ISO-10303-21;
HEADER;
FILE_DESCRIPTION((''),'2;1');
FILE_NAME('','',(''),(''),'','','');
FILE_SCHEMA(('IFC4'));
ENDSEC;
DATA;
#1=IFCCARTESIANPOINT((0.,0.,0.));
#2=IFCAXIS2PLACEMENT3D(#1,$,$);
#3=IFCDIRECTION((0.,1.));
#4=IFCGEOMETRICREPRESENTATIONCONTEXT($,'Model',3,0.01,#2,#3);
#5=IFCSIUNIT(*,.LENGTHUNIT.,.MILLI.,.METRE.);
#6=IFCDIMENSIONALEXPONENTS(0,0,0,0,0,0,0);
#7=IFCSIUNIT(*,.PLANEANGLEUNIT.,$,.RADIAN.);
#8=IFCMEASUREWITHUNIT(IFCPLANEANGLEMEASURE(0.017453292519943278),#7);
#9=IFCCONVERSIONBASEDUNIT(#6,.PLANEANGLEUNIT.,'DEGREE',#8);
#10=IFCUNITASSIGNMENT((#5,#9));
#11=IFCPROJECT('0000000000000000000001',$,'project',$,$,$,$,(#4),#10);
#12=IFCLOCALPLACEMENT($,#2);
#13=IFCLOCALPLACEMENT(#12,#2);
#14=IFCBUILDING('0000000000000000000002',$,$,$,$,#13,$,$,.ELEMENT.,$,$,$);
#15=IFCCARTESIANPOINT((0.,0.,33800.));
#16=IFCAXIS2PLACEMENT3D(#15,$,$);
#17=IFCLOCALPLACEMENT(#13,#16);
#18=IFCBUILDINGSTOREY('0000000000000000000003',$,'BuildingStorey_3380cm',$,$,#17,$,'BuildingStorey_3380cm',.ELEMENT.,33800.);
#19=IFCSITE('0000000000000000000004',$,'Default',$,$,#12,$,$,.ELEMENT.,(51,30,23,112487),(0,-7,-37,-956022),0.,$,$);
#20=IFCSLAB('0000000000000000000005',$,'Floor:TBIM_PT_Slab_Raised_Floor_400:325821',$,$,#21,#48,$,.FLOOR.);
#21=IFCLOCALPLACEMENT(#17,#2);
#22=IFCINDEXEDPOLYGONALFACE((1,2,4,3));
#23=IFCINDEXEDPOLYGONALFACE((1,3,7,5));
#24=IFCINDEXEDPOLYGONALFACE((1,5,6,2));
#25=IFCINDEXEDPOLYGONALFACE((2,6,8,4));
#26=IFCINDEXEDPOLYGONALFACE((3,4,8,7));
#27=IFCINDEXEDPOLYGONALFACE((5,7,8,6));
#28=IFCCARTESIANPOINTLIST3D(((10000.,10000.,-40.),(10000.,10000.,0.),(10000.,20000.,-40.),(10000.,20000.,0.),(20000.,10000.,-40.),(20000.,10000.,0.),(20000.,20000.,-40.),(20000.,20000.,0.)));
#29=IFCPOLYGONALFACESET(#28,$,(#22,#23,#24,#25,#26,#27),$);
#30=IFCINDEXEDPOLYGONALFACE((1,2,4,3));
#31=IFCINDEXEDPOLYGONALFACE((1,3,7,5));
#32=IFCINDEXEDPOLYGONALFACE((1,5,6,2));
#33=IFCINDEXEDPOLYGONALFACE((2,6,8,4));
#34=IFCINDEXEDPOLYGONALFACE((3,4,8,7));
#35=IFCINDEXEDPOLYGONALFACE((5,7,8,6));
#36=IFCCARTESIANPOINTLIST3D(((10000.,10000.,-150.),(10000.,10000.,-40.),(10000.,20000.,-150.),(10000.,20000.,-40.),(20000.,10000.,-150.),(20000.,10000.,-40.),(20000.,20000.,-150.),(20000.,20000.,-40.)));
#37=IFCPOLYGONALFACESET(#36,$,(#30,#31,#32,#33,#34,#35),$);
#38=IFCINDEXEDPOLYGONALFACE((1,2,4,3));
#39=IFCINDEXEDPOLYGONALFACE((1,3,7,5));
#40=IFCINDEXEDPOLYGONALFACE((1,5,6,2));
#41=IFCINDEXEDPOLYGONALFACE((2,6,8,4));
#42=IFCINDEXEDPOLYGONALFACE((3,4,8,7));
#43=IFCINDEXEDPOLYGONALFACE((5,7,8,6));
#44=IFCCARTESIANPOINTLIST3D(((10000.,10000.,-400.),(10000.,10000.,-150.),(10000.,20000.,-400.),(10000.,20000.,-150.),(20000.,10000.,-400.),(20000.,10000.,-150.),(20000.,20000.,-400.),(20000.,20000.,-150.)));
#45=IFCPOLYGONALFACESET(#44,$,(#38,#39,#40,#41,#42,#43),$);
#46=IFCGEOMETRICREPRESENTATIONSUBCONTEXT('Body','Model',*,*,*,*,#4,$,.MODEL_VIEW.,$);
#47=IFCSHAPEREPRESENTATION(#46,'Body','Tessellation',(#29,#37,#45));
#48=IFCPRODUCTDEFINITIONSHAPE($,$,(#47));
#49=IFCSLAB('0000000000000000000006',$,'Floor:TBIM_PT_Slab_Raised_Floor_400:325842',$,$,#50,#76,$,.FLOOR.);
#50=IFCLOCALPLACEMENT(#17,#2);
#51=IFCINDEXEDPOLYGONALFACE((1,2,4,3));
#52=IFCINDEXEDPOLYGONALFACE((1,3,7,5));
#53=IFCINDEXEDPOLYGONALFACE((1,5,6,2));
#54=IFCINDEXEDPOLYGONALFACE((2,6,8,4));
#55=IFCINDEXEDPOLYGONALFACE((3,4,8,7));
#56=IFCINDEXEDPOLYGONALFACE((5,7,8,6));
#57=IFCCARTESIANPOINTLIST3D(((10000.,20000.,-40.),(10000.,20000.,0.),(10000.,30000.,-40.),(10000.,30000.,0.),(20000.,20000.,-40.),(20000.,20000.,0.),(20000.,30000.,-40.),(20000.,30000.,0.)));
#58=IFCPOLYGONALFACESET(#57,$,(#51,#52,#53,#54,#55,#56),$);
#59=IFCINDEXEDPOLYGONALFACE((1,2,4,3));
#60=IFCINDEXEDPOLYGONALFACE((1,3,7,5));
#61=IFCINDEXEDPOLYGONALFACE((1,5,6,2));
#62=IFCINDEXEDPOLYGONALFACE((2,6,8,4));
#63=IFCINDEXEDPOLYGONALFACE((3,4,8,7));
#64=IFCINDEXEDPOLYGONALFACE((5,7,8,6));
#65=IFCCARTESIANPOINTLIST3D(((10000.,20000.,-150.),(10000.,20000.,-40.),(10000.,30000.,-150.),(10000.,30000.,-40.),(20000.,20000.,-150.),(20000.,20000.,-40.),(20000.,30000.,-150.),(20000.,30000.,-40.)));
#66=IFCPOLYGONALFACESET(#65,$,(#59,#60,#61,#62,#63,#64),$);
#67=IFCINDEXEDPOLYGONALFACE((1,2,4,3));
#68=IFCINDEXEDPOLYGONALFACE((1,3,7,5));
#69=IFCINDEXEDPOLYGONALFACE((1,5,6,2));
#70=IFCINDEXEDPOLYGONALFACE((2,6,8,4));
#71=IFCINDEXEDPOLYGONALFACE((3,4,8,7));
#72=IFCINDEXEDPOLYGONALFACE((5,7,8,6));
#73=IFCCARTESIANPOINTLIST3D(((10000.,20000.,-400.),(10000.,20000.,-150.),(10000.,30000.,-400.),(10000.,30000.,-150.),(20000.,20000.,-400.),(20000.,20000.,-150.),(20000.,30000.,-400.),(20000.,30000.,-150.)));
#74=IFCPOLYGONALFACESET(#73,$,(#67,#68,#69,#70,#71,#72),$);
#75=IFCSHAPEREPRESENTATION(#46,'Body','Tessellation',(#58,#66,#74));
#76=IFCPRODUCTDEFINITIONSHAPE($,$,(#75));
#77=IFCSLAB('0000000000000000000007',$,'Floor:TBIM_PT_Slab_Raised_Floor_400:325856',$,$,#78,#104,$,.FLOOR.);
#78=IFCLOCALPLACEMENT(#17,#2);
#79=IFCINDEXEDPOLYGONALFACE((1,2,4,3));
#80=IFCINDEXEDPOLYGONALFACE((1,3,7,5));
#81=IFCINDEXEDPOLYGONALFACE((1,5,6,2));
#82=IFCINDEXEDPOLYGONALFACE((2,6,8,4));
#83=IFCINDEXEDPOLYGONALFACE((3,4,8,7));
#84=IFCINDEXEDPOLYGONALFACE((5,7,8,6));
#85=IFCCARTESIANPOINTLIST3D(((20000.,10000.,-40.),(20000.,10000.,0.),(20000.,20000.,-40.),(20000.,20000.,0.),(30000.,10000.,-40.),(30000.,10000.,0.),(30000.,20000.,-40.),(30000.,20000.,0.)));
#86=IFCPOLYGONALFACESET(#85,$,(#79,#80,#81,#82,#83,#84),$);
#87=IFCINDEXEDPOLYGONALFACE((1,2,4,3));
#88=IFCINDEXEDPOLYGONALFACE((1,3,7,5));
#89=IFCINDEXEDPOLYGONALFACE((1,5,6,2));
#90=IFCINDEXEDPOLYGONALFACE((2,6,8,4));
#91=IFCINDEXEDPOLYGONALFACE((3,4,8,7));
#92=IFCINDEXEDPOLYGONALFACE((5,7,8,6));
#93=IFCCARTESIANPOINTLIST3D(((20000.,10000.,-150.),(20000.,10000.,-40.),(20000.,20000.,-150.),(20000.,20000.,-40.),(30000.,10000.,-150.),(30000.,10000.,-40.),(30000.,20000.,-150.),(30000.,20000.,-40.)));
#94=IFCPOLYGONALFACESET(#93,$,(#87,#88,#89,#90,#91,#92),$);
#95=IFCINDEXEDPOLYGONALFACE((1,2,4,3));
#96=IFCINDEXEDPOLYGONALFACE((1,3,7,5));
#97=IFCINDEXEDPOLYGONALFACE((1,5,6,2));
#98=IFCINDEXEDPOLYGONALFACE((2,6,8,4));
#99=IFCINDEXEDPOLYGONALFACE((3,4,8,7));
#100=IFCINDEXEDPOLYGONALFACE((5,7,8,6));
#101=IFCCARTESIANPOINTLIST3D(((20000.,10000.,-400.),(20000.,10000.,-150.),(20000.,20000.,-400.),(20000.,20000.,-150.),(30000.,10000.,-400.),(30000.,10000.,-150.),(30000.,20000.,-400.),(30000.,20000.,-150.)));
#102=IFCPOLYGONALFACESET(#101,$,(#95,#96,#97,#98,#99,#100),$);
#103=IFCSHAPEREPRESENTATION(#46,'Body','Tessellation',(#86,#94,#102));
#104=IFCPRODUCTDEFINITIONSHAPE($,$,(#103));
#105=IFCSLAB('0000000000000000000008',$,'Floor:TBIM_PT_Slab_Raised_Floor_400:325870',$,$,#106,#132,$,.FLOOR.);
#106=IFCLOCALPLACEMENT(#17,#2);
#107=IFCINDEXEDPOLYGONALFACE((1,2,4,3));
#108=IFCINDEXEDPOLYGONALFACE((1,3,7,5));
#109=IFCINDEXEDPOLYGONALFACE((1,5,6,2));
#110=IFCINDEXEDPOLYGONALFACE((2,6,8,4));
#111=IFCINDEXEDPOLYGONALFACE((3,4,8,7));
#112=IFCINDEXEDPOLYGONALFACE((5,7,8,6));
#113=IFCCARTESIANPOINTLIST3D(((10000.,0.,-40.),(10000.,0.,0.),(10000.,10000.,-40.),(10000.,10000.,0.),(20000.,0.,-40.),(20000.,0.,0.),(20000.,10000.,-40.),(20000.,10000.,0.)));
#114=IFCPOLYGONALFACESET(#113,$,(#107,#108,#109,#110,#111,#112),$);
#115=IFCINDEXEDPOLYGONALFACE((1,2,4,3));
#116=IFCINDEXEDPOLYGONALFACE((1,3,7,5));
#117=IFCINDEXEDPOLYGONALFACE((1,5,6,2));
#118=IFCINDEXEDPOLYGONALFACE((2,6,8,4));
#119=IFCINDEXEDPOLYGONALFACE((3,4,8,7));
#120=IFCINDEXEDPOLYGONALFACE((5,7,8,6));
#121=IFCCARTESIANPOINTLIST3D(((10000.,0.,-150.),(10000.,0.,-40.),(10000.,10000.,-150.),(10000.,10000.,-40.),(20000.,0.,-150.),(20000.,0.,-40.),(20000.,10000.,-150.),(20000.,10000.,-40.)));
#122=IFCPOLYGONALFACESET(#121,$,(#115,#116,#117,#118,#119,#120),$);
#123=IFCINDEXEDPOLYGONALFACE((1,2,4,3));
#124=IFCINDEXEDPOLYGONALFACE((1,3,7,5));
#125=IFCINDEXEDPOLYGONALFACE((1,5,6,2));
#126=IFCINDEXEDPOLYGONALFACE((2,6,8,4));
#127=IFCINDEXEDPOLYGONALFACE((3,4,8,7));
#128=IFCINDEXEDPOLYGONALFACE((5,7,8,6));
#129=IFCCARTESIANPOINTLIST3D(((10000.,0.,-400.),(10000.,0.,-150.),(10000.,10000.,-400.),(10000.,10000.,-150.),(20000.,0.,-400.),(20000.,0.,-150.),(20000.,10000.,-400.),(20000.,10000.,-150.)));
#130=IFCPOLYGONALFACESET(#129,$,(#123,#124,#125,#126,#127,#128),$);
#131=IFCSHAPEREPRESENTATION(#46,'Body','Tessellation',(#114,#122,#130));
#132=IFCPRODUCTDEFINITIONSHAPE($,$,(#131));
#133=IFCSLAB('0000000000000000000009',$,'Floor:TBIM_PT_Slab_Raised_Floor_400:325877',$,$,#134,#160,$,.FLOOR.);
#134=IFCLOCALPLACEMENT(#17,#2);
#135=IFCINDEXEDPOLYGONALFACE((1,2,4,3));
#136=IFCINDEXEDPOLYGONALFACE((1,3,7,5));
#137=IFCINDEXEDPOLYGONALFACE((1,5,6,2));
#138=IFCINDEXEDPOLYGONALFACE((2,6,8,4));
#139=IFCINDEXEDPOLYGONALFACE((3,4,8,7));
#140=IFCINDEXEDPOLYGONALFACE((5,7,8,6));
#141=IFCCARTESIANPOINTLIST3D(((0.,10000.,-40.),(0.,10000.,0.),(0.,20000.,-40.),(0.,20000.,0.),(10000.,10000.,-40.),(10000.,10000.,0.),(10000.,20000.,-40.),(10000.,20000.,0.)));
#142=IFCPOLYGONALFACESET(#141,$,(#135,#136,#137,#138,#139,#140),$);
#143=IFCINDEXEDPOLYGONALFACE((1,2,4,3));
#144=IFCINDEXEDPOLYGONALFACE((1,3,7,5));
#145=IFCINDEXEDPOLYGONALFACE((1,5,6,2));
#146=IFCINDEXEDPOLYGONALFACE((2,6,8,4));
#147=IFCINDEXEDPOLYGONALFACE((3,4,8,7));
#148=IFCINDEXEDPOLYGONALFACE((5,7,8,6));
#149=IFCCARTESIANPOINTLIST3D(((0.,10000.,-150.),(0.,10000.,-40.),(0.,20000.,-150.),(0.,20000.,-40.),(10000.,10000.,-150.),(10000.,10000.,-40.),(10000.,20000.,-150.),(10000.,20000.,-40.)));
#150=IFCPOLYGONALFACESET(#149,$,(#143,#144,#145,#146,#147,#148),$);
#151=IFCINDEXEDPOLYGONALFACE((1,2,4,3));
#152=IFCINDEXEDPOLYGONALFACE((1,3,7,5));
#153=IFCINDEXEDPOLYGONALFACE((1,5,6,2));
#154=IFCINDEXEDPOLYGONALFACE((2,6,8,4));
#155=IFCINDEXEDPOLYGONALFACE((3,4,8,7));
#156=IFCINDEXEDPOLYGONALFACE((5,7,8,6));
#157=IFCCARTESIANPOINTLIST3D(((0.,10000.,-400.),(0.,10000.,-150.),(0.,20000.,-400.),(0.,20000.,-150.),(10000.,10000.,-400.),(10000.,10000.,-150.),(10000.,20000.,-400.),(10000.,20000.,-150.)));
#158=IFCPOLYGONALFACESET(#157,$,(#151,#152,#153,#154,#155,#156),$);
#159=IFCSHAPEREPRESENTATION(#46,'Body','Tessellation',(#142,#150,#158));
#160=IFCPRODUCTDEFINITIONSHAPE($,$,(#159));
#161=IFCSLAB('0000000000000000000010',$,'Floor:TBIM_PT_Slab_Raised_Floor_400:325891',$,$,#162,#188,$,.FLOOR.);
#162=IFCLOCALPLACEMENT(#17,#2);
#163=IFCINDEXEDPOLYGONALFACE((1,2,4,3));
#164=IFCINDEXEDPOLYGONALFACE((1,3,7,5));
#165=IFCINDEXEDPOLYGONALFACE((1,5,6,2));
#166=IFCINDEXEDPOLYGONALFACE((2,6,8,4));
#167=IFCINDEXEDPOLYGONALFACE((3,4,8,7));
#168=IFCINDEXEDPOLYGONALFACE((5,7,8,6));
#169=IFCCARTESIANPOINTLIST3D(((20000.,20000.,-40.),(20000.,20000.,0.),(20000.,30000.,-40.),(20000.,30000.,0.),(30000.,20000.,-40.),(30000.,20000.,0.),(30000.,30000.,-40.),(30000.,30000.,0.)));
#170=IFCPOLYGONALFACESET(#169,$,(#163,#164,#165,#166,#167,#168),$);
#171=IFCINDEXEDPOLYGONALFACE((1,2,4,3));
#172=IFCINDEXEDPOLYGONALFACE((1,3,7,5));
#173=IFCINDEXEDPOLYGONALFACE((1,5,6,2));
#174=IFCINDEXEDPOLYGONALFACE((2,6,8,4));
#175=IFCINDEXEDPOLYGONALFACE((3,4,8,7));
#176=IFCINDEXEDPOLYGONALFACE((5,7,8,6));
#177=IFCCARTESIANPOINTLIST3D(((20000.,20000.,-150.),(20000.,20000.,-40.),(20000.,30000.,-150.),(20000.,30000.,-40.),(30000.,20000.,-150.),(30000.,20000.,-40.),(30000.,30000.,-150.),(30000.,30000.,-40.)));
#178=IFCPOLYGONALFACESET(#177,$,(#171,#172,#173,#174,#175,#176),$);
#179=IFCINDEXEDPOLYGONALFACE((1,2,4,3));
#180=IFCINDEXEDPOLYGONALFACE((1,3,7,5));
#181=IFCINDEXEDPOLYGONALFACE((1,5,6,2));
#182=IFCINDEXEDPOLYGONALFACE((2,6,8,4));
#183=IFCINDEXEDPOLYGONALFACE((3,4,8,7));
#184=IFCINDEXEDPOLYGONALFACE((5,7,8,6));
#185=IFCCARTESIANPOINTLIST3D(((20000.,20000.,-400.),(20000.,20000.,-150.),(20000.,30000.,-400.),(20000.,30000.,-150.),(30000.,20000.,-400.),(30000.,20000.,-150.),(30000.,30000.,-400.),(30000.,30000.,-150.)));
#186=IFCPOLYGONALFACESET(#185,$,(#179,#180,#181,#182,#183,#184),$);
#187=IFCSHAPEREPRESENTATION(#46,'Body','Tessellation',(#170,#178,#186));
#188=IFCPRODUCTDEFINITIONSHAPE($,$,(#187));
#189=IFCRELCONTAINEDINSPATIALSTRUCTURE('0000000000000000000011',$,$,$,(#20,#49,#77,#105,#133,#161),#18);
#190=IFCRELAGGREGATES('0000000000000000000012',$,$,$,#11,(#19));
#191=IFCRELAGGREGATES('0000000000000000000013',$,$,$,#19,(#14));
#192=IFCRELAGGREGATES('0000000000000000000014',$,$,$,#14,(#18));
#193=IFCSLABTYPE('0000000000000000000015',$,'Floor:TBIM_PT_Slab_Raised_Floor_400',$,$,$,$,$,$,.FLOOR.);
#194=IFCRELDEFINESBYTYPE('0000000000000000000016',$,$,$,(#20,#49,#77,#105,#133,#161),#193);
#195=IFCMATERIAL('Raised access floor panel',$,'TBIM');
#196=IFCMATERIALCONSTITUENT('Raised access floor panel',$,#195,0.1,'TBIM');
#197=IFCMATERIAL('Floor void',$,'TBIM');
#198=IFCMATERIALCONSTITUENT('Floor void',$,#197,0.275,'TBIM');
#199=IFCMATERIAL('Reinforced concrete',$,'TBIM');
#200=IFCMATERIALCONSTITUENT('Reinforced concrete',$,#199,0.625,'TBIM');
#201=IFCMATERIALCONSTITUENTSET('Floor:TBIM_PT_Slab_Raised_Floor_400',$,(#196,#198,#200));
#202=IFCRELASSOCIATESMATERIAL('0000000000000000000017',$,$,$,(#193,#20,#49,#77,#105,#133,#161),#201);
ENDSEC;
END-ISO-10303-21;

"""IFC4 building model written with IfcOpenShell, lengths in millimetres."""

from ifc_helpers import new_model, entity, si_unit, converted_unit, direction, frame, origin, place, context, subcontext, project, spatial, indexed_curve, outline, extrude, material, constituent, constituent_set, type_object, element, save


model = new_model("IFC4")

# Units and contexts
model_context = context("Model", 3, precision=0.01, world=origin(), true_north=direction((0.0, 1.0)))
body_context = subcontext(model_context, "Body", "Model", "MODEL_VIEW")
ifc_project = project(units=[si_unit("LENGTHUNIT", "METRE", prefix="MILLI"), converted_unit("PLANEANGLEUNIT", "DEGREE", entity("IfcPlaneAngleMeasure", 0.017453292519943278), si_unit("PLANEANGLEUNIT", "RADIAN"), dimensions=[0, 0, 0, 0, 0, 0, 0])], contexts=[model_context])

# Site, building, storey
site_placement = place(None, origin())
site = spatial("IfcSite", under=ifc_project, at=site_placement, Name="Default", CompositionType="ELEMENT", RefLatitude=(51, 30, 23, 112487), RefLongitude=(0, -7, -37, -956022), RefElevation=0.0)
building_placement = place(site_placement, origin())
building = spatial("IfcBuilding", under=site, at=building_placement, CompositionType="ELEMENT")
storey_placement = place(building_placement, frame((0.0, 0.0, 33800.0)))
storey = spatial("IfcBuildingStorey", under=building, at=storey_placement, Name="BuildingStorey_3380cm", LongName="BuildingStorey_3380cm", CompositionType="ELEMENT", Elevation=33800.0)

# Slabs
ifc_material_1 = material(Name="Raised access floor panel", Category="TBIM")
ifc_constituent_1 = constituent(ifc_material_1, Name="Raised access floor panel", Category="TBIM", fraction=0.1)
ifc_material_2 = material(Name="Floor void", Category="TBIM")
ifc_constituent_2 = constituent(ifc_material_2, Name="Floor void", Category="TBIM", fraction=0.275)
ifc_material_3 = material(Name="Reinforced concrete", Category="TBIM")
ifc_constituent_3 = constituent(ifc_material_3, Name="Reinforced concrete", Category="TBIM", fraction=0.625)
ifc_constituent_set_1 = constituent_set(constituents=[ifc_constituent_1, ifc_constituent_2, ifc_constituent_3], Name="Floor:TBIM_PT_Slab_Raised_Floor_400")
slab_type = type_object("IfcSlabType", Name="Floor:TBIM_PT_Slab_Raised_Floor_400", PredefinedType="FLOOR", material=ifc_constituent_set_1)
slab_1_placement = place(storey_placement, origin())
element("IfcSlab", 1, at=slab_1_placement, inside=storey, type_object=slab_type, material=ifc_constituent_set_1, Name="Floor:TBIM_PT_Slab_Raised_Floor_400:325821", PredefinedType="FLOOR", context=body_context, shape_type="SweptSolid", body=[
    extrude(outline(indexed_curve([(-5000.0, -5000.0), (5000.0, -5000.0), (5000.0, 5000.0), (-5000.0, 5000.0), (-5000.0, -5000.0)], self_intersect=False)), frame((15000.0, 15000.0, -40.0), z_axis=(0.0, 0.0, 1.0), x_axis=(-1.0, 0.0, 0.0)), (0.0, 0.0, 1.0), 40.0),
    extrude(outline(indexed_curve([(-5000.0, -5000.0), (5000.0, -5000.0), (5000.0, 5000.0), (-5000.0, 5000.0), (-5000.0, -5000.0)], self_intersect=False)), frame((15000.0, 15000.0, -150.0), z_axis=(0.0, 0.0, 1.0), x_axis=(-1.0, 0.0, 0.0)), (0.0, 0.0, 1.0), 110.0),
    extrude(outline(indexed_curve([(-5000.0, -5000.0), (5000.0, -5000.0), (5000.0, 5000.0), (-5000.0, 5000.0), (-5000.0, -5000.0)], self_intersect=False)), frame((15000.0, 15000.0, -400.0), z_axis=(0.0, 0.0, 1.0), x_axis=(-1.0, 0.0, 0.0)), (0.0, 0.0, 1.0), 250.0),
])
slab_2_placement = place(storey_placement, origin())
element("IfcSlab", 2, at=slab_2_placement, inside=storey, type_object=slab_type, material=ifc_constituent_set_1, Name="Floor:TBIM_PT_Slab_Raised_Floor_400:325842", PredefinedType="FLOOR", context=body_context, shape_type="SweptSolid", body=[
    extrude(outline(indexed_curve([(-5000.0, -5000.0), (5000.0, -5000.0), (5000.0, 5000.0), (-5000.0, 5000.0), (-5000.0, -5000.0)], self_intersect=False)), frame((15000.0, 25000.0, -40.0), z_axis=(0.0, 0.0, 1.0), x_axis=(-1.0, 0.0, 0.0)), (0.0, 0.0, 1.0), 40.0),
    extrude(outline(indexed_curve([(-5000.0, -5000.0), (5000.0, -5000.0), (5000.0, 5000.0), (-5000.0, 5000.0), (-5000.0, -5000.0)], self_intersect=False)), frame((15000.0, 25000.0, -150.0), z_axis=(0.0, 0.0, 1.0), x_axis=(-1.0, 0.0, 0.0)), (0.0, 0.0, 1.0), 110.0),
    extrude(outline(indexed_curve([(-5000.0, -5000.0), (5000.0, -5000.0), (5000.0, 5000.0), (-5000.0, 5000.0), (-5000.0, -5000.0)], self_intersect=False)), frame((15000.0, 25000.0, -400.0), z_axis=(0.0, 0.0, 1.0), x_axis=(-1.0, 0.0, 0.0)), (0.0, 0.0, 1.0), 250.0),
])
slab_3_placement = place(storey_placement, origin())
element("IfcSlab", 3, at=slab_3_placement, inside=storey, type_object=slab_type, material=ifc_constituent_set_1, Name="Floor:TBIM_PT_Slab_Raised_Floor_400:325856", PredefinedType="FLOOR", context=body_context, shape_type="SweptSolid", body=[
    extrude(outline(indexed_curve([(-5000.0, -5000.0), (5000.0, -5000.0), (5000.0, 5000.0), (-5000.0, 5000.0), (-5000.0, -5000.0)], self_intersect=False)), frame((25000.0, 15000.0, -40.0), z_axis=(0.0, 0.0, 1.0), x_axis=(-1.0, 0.0, 0.0)), (0.0, 0.0, 1.0), 40.0),
    extrude(outline(indexed_curve([(-5000.0, -5000.0), (5000.0, -5000.0), (5000.0, 5000.0), (-5000.0, 5000.0), (-5000.0, -5000.0)], self_intersect=False)), frame((25000.0, 15000.0, -150.0), z_axis=(0.0, 0.0, 1.0), x_axis=(-1.0, 0.0, 0.0)), (0.0, 0.0, 1.0), 110.0),
    extrude(outline(indexed_curve([(-5000.0, -5000.0), (5000.0, -5000.0), (5000.0, 5000.0), (-5000.0, 5000.0), (-5000.0, -5000.0)], self_intersect=False)), frame((25000.0, 15000.0, -400.0), z_axis=(0.0, 0.0, 1.0), x_axis=(-1.0, 0.0, 0.0)), (0.0, 0.0, 1.0), 250.0),
])
slab_4_placement = place(storey_placement, origin())
element("IfcSlab", 4, at=slab_4_placement, inside=storey, type_object=slab_type, material=ifc_constituent_set_1, Name="Floor:TBIM_PT_Slab_Raised_Floor_400:325870", PredefinedType="FLOOR", context=body_context, shape_type="SweptSolid", body=[
    extrude(outline(indexed_curve([(-5000.0, -5000.0), (5000.0, -5000.0), (5000.0, 5000.0), (-5000.0, 5000.0), (-5000.0, -5000.0)], self_intersect=False)), frame((15000.0, 5000.0, -40.0), z_axis=(0.0, 0.0, 1.0), x_axis=(0.0, 1.0, 0.0)), (0.0, 0.0, 1.0), 40.0),
    extrude(outline(indexed_curve([(-5000.0, -5000.0), (5000.0, -5000.0), (5000.0, 5000.0), (-5000.0, 5000.0), (-5000.0, -5000.0)], self_intersect=False)), frame((15000.0, 5000.0, -150.0), z_axis=(0.0, 0.0, 1.0), x_axis=(0.0, 1.0, 0.0)), (0.0, 0.0, 1.0), 110.0),
    extrude(outline(indexed_curve([(-5000.0, -5000.0), (5000.0, -5000.0), (5000.0, 5000.0), (-5000.0, 5000.0), (-5000.0, -5000.0)], self_intersect=False)), frame((15000.0, 5000.0, -400.0), z_axis=(0.0, 0.0, 1.0), x_axis=(0.0, 1.0, 0.0)), (0.0, 0.0, 1.0), 250.0),
])
slab_5_placement = place(storey_placement, origin())
element("IfcSlab", 5, at=slab_5_placement, inside=storey, type_object=slab_type, material=ifc_constituent_set_1, Name="Floor:TBIM_PT_Slab_Raised_Floor_400:325877", PredefinedType="FLOOR", context=body_context, shape_type="SweptSolid", body=[
    extrude(outline(indexed_curve([(-5000.0, -5000.0), (5000.0, -5000.0), (5000.0, 5000.0), (-5000.0, 5000.0), (-5000.0, -5000.0)], self_intersect=False)), frame((5000.0, 15000.0, -40.0), z_axis=(0.0, 0.0, 1.0), x_axis=(0.0, 1.0, 0.0)), (0.0, 0.0, 1.0), 40.0),
    extrude(outline(indexed_curve([(-5000.0, -5000.0), (5000.0, -5000.0), (5000.0, 5000.0), (-5000.0, 5000.0), (-5000.0, -5000.0)], self_intersect=False)), frame((5000.0, 15000.0, -150.0), z_axis=(0.0, 0.0, 1.0), x_axis=(0.0, 1.0, 0.0)), (0.0, 0.0, 1.0), 110.0),
    extrude(outline(indexed_curve([(-5000.0, -5000.0), (5000.0, -5000.0), (5000.0, 5000.0), (-5000.0, 5000.0), (-5000.0, -5000.0)], self_intersect=False)), frame((5000.0, 15000.0, -400.0), z_axis=(0.0, 0.0, 1.0), x_axis=(0.0, 1.0, 0.0)), (0.0, 0.0, 1.0), 250.0),
])
slab_6_placement = place(storey_placement, origin())
element("IfcSlab", 6, at=slab_6_placement, inside=storey, type_object=slab_type, material=ifc_constituent_set_1, Name="Floor:TBIM_PT_Slab_Raised_Floor_400:325891", PredefinedType="FLOOR", context=body_context, shape_type="SweptSolid", body=[
    extrude(outline(indexed_curve([(-5000.0, -5000.0), (5000.0, -5000.0), (5000.0, 5000.0), (-5000.0, 5000.0), (-5000.0, -5000.0)], self_intersect=False)), frame((25000.0, 25000.0, -40.0), z_axis=(0.0, 0.0, 1.0), x_axis=(-1.0, 0.0, 0.0)), (0.0, 0.0, 1.0), 40.0),
    extrude(outline(indexed_curve([(-5000.0, -5000.0), (5000.0, -5000.0), (5000.0, 5000.0), (-5000.0, 5000.0), (-5000.0, -5000.0)], self_intersect=False)), frame((25000.0, 25000.0, -150.0), z_axis=(0.0, 0.0, 1.0), x_axis=(-1.0, 0.0, 0.0)), (0.0, 0.0, 1.0), 110.0),
    extrude(outline(indexed_curve([(-5000.0, -5000.0), (5000.0, -5000.0), (5000.0, 5000.0), (-5000.0, 5000.0), (-5000.0, -5000.0)], self_intersect=False)), frame((25000.0, 25000.0, -400.0), z_axis=(0.0, 0.0, 1.0), x_axis=(-1.0, 0.0, 0.0)), (0.0, 0.0, 1.0), 250.0),
])

save(model, "model.ifc")
